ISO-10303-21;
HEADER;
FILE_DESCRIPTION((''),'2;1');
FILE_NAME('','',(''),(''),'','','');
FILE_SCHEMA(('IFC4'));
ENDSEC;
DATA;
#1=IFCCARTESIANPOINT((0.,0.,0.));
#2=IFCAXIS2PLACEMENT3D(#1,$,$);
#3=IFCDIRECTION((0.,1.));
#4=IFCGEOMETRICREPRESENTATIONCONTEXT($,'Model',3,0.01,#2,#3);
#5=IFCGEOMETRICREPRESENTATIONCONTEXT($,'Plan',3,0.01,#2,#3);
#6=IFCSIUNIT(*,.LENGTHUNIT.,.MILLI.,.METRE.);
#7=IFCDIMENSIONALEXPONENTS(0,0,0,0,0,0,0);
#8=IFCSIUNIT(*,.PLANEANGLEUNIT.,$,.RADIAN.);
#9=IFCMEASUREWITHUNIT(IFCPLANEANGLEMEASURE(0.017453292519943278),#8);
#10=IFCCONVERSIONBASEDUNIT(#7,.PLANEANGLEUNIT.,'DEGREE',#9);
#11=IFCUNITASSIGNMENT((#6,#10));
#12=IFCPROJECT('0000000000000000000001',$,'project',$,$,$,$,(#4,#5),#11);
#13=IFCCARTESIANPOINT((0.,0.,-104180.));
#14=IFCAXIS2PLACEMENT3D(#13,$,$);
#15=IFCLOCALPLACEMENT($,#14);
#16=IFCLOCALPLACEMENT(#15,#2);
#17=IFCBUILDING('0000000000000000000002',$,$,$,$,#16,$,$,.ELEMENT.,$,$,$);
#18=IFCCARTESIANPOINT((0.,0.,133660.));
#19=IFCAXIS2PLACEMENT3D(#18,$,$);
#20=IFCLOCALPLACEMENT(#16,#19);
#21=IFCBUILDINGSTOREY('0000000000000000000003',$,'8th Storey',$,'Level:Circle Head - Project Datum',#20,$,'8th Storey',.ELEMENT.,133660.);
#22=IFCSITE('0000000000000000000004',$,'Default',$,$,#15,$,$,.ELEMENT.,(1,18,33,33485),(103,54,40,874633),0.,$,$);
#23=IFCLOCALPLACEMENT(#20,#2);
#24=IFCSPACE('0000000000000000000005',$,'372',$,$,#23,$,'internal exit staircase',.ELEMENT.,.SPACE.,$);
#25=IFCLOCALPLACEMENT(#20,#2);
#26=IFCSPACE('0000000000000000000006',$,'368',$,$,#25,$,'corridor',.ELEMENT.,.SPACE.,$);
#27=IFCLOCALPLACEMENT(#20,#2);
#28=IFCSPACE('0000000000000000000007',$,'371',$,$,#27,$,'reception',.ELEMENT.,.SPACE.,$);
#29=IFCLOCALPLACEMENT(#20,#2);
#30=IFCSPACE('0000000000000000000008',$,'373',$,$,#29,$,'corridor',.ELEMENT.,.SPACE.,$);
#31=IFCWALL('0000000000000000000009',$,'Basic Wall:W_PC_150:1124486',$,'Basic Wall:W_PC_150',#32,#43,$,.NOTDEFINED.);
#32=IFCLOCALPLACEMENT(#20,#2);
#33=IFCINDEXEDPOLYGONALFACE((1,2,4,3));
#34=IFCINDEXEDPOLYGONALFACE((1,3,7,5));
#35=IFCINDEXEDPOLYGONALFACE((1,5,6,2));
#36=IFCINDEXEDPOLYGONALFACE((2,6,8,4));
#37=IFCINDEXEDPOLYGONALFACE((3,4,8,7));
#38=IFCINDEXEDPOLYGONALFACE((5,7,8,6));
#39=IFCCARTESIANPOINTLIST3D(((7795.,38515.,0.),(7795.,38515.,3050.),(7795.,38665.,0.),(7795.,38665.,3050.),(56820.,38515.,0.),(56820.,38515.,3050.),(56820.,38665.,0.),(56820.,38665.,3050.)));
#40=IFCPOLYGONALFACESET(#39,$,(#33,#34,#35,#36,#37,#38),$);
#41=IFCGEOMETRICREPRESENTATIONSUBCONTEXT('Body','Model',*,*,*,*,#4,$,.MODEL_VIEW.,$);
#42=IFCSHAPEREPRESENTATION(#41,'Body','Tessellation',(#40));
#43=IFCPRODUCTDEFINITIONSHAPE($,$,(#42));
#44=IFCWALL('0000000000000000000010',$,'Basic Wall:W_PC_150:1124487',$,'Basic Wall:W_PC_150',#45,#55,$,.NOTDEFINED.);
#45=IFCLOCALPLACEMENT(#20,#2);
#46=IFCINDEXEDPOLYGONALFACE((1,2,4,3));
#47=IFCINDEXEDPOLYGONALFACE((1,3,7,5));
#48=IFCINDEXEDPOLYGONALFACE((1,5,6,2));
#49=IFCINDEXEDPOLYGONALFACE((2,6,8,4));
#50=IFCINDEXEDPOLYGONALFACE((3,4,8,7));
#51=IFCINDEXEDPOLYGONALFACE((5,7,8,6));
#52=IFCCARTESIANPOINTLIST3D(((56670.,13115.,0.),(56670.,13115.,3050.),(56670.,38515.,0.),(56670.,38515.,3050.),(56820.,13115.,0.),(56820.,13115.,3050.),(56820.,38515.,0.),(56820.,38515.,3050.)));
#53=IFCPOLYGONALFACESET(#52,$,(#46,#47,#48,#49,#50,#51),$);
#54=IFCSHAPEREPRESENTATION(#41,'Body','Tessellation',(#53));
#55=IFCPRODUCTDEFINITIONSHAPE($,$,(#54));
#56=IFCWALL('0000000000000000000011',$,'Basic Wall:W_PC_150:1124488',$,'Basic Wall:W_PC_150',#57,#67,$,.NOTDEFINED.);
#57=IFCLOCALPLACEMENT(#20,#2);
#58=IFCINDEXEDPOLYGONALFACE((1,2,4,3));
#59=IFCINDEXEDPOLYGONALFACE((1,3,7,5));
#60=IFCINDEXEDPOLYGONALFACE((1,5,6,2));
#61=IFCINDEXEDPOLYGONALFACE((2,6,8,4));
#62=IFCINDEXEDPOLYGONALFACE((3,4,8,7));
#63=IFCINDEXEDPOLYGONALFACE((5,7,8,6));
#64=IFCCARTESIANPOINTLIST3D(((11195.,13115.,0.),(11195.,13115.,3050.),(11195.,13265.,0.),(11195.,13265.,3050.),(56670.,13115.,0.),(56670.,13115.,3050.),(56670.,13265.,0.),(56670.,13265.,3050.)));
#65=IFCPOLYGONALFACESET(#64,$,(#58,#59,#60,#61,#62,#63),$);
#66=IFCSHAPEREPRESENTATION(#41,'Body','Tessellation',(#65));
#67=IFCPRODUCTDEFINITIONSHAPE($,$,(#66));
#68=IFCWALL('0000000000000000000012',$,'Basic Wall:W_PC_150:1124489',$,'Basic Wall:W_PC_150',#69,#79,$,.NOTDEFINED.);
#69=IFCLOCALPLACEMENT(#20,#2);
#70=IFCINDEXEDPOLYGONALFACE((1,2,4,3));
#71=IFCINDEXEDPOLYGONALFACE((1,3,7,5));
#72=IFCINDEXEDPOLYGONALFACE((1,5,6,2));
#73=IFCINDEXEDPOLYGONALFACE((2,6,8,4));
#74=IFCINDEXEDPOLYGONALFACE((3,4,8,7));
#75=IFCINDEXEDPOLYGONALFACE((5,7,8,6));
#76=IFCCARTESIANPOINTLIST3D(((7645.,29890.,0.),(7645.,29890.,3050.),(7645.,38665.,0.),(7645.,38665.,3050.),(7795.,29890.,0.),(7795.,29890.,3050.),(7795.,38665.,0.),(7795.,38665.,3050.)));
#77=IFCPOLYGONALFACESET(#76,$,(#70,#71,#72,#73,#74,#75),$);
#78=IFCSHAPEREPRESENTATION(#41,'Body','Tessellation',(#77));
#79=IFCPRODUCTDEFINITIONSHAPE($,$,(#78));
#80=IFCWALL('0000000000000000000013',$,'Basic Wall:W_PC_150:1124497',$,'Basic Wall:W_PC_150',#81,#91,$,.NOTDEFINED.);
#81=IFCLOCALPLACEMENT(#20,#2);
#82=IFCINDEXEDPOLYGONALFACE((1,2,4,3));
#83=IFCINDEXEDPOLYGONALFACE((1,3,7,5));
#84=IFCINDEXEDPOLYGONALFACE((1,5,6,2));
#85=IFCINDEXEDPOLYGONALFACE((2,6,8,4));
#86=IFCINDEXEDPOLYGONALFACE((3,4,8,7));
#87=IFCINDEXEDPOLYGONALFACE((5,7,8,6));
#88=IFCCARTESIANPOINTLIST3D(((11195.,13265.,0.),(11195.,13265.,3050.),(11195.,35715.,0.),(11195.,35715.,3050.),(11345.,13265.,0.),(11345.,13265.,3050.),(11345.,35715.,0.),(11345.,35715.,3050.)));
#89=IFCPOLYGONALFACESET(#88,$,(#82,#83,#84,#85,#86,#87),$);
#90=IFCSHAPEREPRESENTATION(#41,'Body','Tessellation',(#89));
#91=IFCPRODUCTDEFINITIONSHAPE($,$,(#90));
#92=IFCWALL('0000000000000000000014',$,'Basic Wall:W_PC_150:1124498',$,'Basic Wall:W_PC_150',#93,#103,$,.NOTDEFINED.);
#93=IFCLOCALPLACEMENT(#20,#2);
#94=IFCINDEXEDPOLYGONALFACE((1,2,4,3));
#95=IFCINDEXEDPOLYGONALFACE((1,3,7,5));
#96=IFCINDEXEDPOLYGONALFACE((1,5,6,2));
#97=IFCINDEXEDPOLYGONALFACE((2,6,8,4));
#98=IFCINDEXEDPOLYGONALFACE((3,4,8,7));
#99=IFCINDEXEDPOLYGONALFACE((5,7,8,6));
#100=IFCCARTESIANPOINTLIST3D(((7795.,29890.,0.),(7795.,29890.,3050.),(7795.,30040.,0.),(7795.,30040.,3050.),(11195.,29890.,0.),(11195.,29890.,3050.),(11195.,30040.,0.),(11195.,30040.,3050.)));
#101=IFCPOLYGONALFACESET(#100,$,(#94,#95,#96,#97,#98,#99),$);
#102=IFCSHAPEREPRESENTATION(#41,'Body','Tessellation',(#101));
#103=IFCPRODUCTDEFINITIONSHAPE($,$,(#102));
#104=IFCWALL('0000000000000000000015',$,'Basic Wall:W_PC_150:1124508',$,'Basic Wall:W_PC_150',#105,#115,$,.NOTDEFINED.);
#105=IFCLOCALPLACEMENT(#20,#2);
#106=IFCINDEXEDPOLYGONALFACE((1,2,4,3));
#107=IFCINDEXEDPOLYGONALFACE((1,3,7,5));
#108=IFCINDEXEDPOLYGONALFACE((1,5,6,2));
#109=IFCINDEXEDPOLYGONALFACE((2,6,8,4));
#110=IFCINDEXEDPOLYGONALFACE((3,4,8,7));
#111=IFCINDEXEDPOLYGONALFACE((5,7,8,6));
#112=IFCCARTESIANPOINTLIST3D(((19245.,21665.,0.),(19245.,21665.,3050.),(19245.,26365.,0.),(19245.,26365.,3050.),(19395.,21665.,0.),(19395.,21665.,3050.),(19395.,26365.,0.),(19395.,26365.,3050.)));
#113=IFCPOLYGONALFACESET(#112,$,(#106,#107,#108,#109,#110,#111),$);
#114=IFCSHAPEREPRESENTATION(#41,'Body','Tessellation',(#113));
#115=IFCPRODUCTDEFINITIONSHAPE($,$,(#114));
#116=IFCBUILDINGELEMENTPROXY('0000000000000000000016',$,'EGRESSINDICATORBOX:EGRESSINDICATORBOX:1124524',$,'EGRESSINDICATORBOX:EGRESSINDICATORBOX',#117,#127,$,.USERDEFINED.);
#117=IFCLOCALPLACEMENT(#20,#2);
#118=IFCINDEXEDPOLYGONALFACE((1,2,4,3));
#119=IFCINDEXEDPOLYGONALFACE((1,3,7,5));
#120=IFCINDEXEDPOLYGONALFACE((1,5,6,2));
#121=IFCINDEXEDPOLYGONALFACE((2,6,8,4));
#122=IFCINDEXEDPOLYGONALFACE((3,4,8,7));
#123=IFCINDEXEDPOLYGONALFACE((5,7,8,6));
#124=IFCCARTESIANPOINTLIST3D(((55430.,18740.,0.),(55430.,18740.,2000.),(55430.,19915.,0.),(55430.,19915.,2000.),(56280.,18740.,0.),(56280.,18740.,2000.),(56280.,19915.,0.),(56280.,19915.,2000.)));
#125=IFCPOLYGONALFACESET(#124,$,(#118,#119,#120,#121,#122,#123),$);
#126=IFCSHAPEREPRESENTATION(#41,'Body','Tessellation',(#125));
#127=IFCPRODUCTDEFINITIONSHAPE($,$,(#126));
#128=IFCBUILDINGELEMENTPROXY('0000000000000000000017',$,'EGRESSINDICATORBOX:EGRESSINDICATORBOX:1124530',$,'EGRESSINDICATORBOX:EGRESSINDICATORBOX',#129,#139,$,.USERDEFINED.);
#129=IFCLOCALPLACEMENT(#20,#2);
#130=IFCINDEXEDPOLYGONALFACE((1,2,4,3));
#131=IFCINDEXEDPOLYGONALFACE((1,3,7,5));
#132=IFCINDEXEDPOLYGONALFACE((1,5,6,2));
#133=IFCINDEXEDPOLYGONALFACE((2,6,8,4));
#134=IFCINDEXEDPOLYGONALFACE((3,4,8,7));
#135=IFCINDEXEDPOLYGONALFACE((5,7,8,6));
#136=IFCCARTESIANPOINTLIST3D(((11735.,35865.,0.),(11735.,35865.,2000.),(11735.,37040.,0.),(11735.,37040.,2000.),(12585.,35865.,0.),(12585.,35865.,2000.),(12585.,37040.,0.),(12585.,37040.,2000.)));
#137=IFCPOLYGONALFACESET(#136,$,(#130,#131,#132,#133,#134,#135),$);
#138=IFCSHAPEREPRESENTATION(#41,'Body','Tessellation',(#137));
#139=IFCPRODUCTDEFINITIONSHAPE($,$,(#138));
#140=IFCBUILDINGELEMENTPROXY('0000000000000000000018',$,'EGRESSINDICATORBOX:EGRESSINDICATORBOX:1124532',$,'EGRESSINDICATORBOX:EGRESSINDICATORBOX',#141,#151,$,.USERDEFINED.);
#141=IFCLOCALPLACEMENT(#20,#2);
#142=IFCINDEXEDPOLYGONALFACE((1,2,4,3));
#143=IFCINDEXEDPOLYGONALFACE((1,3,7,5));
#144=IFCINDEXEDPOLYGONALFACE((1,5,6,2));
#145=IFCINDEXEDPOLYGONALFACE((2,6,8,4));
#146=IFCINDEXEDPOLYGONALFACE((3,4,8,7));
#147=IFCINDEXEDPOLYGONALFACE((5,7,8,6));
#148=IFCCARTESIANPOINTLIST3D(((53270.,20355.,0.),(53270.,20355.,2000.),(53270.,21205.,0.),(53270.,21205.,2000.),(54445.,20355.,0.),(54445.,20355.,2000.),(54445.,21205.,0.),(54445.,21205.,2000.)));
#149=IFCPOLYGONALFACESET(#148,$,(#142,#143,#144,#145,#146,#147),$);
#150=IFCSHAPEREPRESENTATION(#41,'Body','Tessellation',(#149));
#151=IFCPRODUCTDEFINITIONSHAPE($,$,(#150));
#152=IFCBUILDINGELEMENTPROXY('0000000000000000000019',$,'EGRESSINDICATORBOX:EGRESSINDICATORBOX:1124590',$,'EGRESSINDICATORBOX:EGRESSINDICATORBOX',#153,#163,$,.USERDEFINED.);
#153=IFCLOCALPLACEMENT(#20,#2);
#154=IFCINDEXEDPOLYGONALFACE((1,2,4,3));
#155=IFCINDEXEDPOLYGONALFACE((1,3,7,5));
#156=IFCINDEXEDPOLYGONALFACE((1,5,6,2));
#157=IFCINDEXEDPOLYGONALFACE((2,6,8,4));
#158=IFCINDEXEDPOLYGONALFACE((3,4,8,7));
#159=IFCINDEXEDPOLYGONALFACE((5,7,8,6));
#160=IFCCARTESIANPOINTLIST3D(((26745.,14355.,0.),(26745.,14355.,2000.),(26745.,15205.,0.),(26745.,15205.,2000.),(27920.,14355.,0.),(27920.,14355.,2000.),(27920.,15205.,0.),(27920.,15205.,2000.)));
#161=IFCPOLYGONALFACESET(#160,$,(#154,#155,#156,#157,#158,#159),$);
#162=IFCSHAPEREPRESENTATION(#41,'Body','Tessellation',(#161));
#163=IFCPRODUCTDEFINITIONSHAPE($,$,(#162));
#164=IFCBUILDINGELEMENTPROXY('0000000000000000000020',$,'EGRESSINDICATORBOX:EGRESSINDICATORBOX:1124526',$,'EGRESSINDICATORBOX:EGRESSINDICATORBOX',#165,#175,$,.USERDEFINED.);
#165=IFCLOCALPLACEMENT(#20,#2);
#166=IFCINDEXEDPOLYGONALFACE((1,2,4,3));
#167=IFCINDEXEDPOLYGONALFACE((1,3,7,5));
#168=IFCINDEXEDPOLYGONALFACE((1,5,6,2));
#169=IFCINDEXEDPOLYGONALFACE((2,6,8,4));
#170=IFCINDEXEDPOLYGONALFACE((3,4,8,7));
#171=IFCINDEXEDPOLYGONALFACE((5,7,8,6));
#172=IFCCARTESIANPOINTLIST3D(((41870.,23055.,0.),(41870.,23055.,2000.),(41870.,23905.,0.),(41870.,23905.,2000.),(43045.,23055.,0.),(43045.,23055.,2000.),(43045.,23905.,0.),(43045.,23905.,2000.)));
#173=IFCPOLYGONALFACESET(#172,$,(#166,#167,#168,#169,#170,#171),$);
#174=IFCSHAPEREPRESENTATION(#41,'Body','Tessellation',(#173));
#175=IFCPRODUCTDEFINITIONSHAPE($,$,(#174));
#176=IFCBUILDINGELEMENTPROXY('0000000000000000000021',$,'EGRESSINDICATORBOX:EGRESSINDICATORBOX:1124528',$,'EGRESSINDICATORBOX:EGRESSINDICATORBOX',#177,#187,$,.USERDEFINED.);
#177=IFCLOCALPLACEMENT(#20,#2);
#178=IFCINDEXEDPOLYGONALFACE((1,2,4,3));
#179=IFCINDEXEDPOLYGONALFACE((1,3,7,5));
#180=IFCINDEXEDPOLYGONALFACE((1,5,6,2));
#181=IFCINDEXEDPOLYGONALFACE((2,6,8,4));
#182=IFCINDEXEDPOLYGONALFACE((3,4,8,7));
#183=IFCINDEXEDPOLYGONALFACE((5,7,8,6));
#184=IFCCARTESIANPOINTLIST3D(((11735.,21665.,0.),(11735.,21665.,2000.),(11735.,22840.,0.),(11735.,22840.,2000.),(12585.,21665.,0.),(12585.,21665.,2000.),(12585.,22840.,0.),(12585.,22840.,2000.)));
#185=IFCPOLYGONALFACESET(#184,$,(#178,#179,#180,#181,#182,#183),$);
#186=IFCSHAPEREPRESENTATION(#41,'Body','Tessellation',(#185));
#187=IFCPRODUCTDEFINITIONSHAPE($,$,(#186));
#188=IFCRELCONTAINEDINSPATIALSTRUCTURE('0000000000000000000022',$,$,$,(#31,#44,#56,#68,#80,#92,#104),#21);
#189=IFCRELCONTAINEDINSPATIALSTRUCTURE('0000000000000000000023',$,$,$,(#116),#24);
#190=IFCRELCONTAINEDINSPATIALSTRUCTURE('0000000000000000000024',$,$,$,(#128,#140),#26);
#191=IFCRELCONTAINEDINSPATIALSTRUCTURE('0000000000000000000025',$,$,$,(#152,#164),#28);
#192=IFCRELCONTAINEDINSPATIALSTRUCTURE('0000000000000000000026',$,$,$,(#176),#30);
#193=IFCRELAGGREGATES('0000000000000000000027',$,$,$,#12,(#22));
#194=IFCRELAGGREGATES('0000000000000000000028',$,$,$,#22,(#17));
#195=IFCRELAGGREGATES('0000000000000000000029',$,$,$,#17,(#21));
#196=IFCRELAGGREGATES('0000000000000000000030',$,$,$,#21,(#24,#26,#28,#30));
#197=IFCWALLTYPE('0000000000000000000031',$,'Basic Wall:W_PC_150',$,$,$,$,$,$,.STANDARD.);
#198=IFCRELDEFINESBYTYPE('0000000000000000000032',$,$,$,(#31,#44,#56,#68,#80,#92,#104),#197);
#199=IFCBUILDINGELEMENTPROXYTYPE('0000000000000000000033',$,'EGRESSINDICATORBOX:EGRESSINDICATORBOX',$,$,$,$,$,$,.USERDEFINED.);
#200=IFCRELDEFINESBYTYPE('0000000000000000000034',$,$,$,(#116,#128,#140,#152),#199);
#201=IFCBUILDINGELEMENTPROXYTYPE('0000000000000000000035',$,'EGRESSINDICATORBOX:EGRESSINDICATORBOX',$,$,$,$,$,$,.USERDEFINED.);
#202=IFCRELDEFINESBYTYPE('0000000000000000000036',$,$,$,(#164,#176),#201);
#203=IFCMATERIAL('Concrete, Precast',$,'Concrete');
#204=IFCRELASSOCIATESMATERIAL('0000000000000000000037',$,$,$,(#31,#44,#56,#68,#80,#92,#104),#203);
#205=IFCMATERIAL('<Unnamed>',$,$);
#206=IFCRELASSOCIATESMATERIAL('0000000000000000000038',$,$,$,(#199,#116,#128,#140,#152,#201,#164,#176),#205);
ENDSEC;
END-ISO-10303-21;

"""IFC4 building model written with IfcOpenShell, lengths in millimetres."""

from ifc_helpers import new_model, entity, si_unit, converted_unit, direction, frame, origin, place, context, subcontext, project, spatial, indexed_curve, outline, extrude, source, transform, mapped, material, type_object, type_shapes, element, save


model = new_model("IFC4")

# Units and contexts
model_context = context("Model", 3, precision=0.01, world=origin(), true_north=direction((0.0, 1.0)))
plan_context = context("Plan", 3, precision=0.01, world=origin(), true_north=direction((0.0, 1.0)))
body_context = subcontext(model_context, "Body", "Model", "MODEL_VIEW")
ifc_project = project(units=[si_unit("LENGTHUNIT", "METRE", prefix="MILLI"), converted_unit("PLANEANGLEUNIT", "DEGREE", entity("IfcPlaneAngleMeasure", 0.017453292519943278), si_unit("PLANEANGLEUNIT", "RADIAN"), dimensions=[0, 0, 0, 0, 0, 0, 0])], contexts=[model_context, plan_context])

# Site, building, storey
site_placement = place(None, frame((0.0, 0.0, -104180.0)))
site = spatial("IfcSite", under=ifc_project, at=site_placement, Name="Default", CompositionType="ELEMENT", RefLatitude=(1, 18, 33, 33485), RefLongitude=(103, 54, 40, 874633), RefElevation=0.0)
building_placement = place(site_placement, origin())
building = spatial("IfcBuilding", under=site, at=building_placement, CompositionType="ELEMENT")
storey_placement = place(building_placement, frame((0.0, 0.0, 133660.0)))
storey = spatial("IfcBuildingStorey", under=building, at=storey_placement, Name="8th Storey", ObjectType="Level:Circle Head - Project Datum", LongName="8th Storey", CompositionType="ELEMENT", Elevation=133660.0)

# Shared definitions
ifc_material_1 = material(Name="Concrete, Precast", Category="Concrete")

# Walls
wall_type = type_object("IfcWallType", Name="Basic Wall:W_PC_150", PredefinedType="STANDARD")
wall_1_placement = place(storey_placement, frame((56820.0, 38590.0, 0.0), z_axis=(0.0, 0.0, 1.0), x_axis=(-1.0, 0.0, 0.0)))
element("IfcWall", 1, at=wall_1_placement, inside=storey, type_object=wall_type, material=ifc_material_1, Name="Basic Wall:W_PC_150:1124486", ObjectType="Basic Wall:W_PC_150", PredefinedType="NOTDEFINED", context=body_context, shape_type="SweptSolid", body=[
    extrude(outline(indexed_curve([(49025.0, 75.0), (0.0, 75.0), (0.0, -75.0), (49025.0, -75.0), (49025.0, 75.0)], self_intersect=False)), origin(), (0.0, 0.0, 1.0), 3050.0),
])
wall_2_placement = place(storey_placement, frame((56745.0, 13115.0, 0.0), z_axis=(0.0, 0.0, 1.0), x_axis=(0.0, 1.0, 0.0)))
element("IfcWall", 2, at=wall_2_placement, inside=storey, type_object=wall_type, material=ifc_material_1, Name="Basic Wall:W_PC_150:1124487", ObjectType="Basic Wall:W_PC_150", PredefinedType="NOTDEFINED", context=body_context, shape_type="SweptSolid", body=[
    extrude(outline(indexed_curve([(25400.0, 75.0), (0.0, 75.0), (0.0, -75.0), (25400.0, -75.0), (25400.0, 75.0)], self_intersect=False)), origin(), (0.0, 0.0, 1.0), 3050.0),
])
wall_3_placement = place(storey_placement, frame((11195.0, 13190.0, 0.0)))
element("IfcWall", 3, at=wall_3_placement, inside=storey, type_object=wall_type, material=ifc_material_1, Name="Basic Wall:W_PC_150:1124488", ObjectType="Basic Wall:W_PC_150", PredefinedType="NOTDEFINED", context=body_context, shape_type="SweptSolid", body=[
    extrude(outline(indexed_curve([(45475.0, 75.0), (0.0, 75.0), (0.0, -75.0), (45475.0, -75.0), (45475.0, 75.0)], self_intersect=False)), origin(), (0.0, 0.0, 1.0), 3050.0),
])
wall_4_placement = place(storey_placement, frame((7720.0, 38665.0, 0.0), z_axis=(0.0, 0.0, 1.0), x_axis=(0.0, -1.0, 0.0)))
element("IfcWall", 4, at=wall_4_placement, inside=storey, type_object=wall_type, material=ifc_material_1, Name="Basic Wall:W_PC_150:1124489", ObjectType="Basic Wall:W_PC_150", PredefinedType="NOTDEFINED", context=body_context, shape_type="SweptSolid", body=[
    extrude(outline(indexed_curve([(8775.0, 75.0), (0.0, 75.0), (0.0, -75.0), (8775.0, -75.0), (8775.0, 75.0)], self_intersect=False)), origin(), (0.0, 0.0, 1.0), 3050.0),
])
wall_5_placement = place(storey_placement, frame((11270.0, 35715.0, 0.0), z_axis=(0.0, 0.0, 1.0), x_axis=(0.0, -1.0, 0.0)))
element("IfcWall", 5, at=wall_5_placement, inside=storey, type_object=wall_type, material=ifc_material_1, Name="Basic Wall:W_PC_150:1124497", ObjectType="Basic Wall:W_PC_150", PredefinedType="NOTDEFINED", context=body_context, shape_type="SweptSolid", body=[
    extrude(outline(indexed_curve([(22450.0, 75.0), (0.0, 75.0), (0.0, -75.0), (22450.0, -75.0), (22450.0, 75.0)], self_intersect=False)), origin(), (0.0, 0.0, 1.0), 3050.0),
])
wall_6_placement = place(storey_placement, frame((7795.0, 29965.0, 0.0)))
element("IfcWall", 6, at=wall_6_placement, inside=storey, type_object=wall_type, material=ifc_material_1, Name="Basic Wall:W_PC_150:1124498", ObjectType="Basic Wall:W_PC_150", PredefinedType="NOTDEFINED", context=body_context, shape_type="SweptSolid", body=[
    extrude(outline(indexed_curve([(3400.0, 75.0), (0.0, 75.0), (0.0, -75.0), (3400.0, -75.0), (3400.0, 75.0)], self_intersect=False)), origin(), (0.0, 0.0, 1.0), 3050.0),
])
wall_7_placement = place(storey_placement, frame((19320.0, 21665.0, 0.0), z_axis=(0.0, 0.0, 1.0), x_axis=(0.0, 1.0, 0.0)))
element("IfcWall", 7, at=wall_7_placement, inside=storey, type_object=wall_type, material=ifc_material_1, Name="Basic Wall:W_PC_150:1124508", ObjectType="Basic Wall:W_PC_150", PredefinedType="NOTDEFINED", context=body_context, shape_type="SweptSolid", body=[
    extrude(outline(indexed_curve([(4700.0, 75.0), (0.0, 75.0), (0.0, -75.0), (4700.0, -75.0), (4700.0, 75.0)], self_intersect=False)), origin(), (0.0, 0.0, 1.0), 3050.0),
])

# Shared definitions
space_1_placement = place(storey_placement, origin())
space_1 = spatial("IfcSpace", under=storey, at=space_1_placement, Name="372", LongName="internal exit staircase", CompositionType="ELEMENT", PredefinedType="SPACE")

# Building element proxy
ifc_material_2 = material(Name="<Unnamed>")
building_element_proxy_type_1 = type_object("IfcBuildingElementProxyType", Name="EGRESSINDICATORBOX:EGRESSINDICATORBOX", PredefinedType="USERDEFINED", material=ifc_material_2)
shared_shape_1 = source(origin(), body_context, "Body", "SweptSolid", [
    extrude(outline(indexed_curve([(-587.5, -425.0), (587.5, -425.0), (587.5, 425.0), (-587.5, 425.0), (-587.5, -425.0)], self_intersect=False)), frame((0.0, 0.0, 0.0), z_axis=(0.0, 0.0, 1.0), x_axis=(0.0, 1.0, 0.0)), (0.0, 0.0, 1.0), 2000.0),
])
type_shapes(building_element_proxy_type_1, [shared_shape_1])
proxy_1_placement = place(space_1_placement, frame((55855.0, 19327.5, 0.0)))
element("IfcBuildingElementProxy", 8, at=proxy_1_placement, inside=space_1, type_object=building_element_proxy_type_1, material=ifc_material_2, Name="EGRESSINDICATORBOX:EGRESSINDICATORBOX:1124524", ObjectType="EGRESSINDICATORBOX:EGRESSINDICATORBOX", PredefinedType="USERDEFINED", context=body_context, shape_type="MappedRepresentation", body=[
    mapped(shared_shape_1, transform((0.0, 0.0, 0.0), scale=1.0)),
])

# Shared definitions
space_2_placement = place(storey_placement, origin())
space_2 = spatial("IfcSpace", under=storey, at=space_2_placement, Name="368", LongName="corridor", CompositionType="ELEMENT", PredefinedType="SPACE")

# Building element proxies
for number, where, z_axis, x_axis, name in (
    (9, (12160.0, 36452.5, 0.0), (0.0, 0.0, 1.0), (-1.0, 0.0, 0.0), "EGRESSINDICATORBOX:EGRESSINDICATORBOX:1124530"),
    (10, (53857.5, 20780.0, 0.0), (0.0, 0.0, 1.0), (0.0, 1.0, 0.0), "EGRESSINDICATORBOX:EGRESSINDICATORBOX:1124532"),
):
    element("IfcBuildingElementProxy", number, at=place(space_2_placement, frame(where, z_axis=z_axis, x_axis=x_axis)), inside=space_2, type_object=building_element_proxy_type_1, material=ifc_material_2, Name=name, ObjectType="EGRESSINDICATORBOX:EGRESSINDICATORBOX", PredefinedType="USERDEFINED", context=body_context, shape_type="MappedRepresentation", body=[
        mapped(shared_shape_1, transform((0.0, 0.0, 0.0), scale=1.0)),
    ])

# Shared definitions
space_3_placement = place(storey_placement, origin())
space_3 = spatial("IfcSpace", under=storey, at=space_3_placement, Name="371", LongName="reception", CompositionType="ELEMENT", PredefinedType="SPACE")

# Building element proxies
proxy_2_placement = place(space_3_placement, frame((27332.5, 14780.0, 0.0), z_axis=(0.0, 0.0, 1.0), x_axis=(0.0, 1.0, 0.0)))
element("IfcBuildingElementProxy", 11, at=proxy_2_placement, inside=space_3, type_object=building_element_proxy_type_1, material=ifc_material_2, Name="EGRESSINDICATORBOX:EGRESSINDICATORBOX:1124590", ObjectType="EGRESSINDICATORBOX:EGRESSINDICATORBOX", PredefinedType="USERDEFINED", context=body_context, shape_type="MappedRepresentation", body=[
    mapped(shared_shape_1, transform((0.0, 0.0, 0.0), scale=1.0)),
])
building_element_proxy_type_2 = type_object("IfcBuildingElementProxyType", Name="EGRESSINDICATORBOX:EGRESSINDICATORBOX", PredefinedType="USERDEFINED", material=ifc_material_2)
shared_shape_2 = source(origin(), body_context, "Body", "SweptSolid", [
    extrude(outline(indexed_curve([(-425.0, -587.5), (425.0, -587.5), (425.0, 587.5), (-425.0, 587.5), (-425.0, -587.5)], self_intersect=False)), frame((0.0, 0.0, 0.0), z_axis=(0.0, 0.0, 1.0), x_axis=(-1.0, 0.0, 0.0)), (0.0, 0.0, 1.0), 2000.0),
])
type_shapes(building_element_proxy_type_2, [shared_shape_2])
proxy_3_placement = place(space_3_placement, frame((42457.5, 23480.0, 0.0), z_axis=(0.0, 0.0, 1.0), x_axis=(0.0, -1.0, 0.0)))
element("IfcBuildingElementProxy", 12, at=proxy_3_placement, inside=space_3, type_object=building_element_proxy_type_2, material=ifc_material_2, Name="EGRESSINDICATORBOX:EGRESSINDICATORBOX:1124526", ObjectType="EGRESSINDICATORBOX:EGRESSINDICATORBOX", PredefinedType="USERDEFINED", context=body_context, shape_type="MappedRepresentation", body=[
    mapped(shared_shape_2, transform((0.0, 0.0, 0.0), scale=1.0)),
])

# Shared definitions
space_4_placement = place(storey_placement, origin())
space_4 = spatial("IfcSpace", under=storey, at=space_4_placement, Name="373", LongName="corridor", CompositionType="ELEMENT", PredefinedType="SPACE")

# Building element proxy
proxy_4_placement = place(space_4_placement, frame((12160.0, 22252.5, 0.0)))
element("IfcBuildingElementProxy", 13, at=proxy_4_placement, inside=space_4, type_object=building_element_proxy_type_2, material=ifc_material_2, Name="EGRESSINDICATORBOX:EGRESSINDICATORBOX:1124528", ObjectType="EGRESSINDICATORBOX:EGRESSINDICATORBOX", PredefinedType="USERDEFINED", context=body_context, shape_type="MappedRepresentation", body=[
    mapped(shared_shape_2, transform((0.0, 0.0, 0.0), scale=1.0)),
])

save(model, "model.ifc")
